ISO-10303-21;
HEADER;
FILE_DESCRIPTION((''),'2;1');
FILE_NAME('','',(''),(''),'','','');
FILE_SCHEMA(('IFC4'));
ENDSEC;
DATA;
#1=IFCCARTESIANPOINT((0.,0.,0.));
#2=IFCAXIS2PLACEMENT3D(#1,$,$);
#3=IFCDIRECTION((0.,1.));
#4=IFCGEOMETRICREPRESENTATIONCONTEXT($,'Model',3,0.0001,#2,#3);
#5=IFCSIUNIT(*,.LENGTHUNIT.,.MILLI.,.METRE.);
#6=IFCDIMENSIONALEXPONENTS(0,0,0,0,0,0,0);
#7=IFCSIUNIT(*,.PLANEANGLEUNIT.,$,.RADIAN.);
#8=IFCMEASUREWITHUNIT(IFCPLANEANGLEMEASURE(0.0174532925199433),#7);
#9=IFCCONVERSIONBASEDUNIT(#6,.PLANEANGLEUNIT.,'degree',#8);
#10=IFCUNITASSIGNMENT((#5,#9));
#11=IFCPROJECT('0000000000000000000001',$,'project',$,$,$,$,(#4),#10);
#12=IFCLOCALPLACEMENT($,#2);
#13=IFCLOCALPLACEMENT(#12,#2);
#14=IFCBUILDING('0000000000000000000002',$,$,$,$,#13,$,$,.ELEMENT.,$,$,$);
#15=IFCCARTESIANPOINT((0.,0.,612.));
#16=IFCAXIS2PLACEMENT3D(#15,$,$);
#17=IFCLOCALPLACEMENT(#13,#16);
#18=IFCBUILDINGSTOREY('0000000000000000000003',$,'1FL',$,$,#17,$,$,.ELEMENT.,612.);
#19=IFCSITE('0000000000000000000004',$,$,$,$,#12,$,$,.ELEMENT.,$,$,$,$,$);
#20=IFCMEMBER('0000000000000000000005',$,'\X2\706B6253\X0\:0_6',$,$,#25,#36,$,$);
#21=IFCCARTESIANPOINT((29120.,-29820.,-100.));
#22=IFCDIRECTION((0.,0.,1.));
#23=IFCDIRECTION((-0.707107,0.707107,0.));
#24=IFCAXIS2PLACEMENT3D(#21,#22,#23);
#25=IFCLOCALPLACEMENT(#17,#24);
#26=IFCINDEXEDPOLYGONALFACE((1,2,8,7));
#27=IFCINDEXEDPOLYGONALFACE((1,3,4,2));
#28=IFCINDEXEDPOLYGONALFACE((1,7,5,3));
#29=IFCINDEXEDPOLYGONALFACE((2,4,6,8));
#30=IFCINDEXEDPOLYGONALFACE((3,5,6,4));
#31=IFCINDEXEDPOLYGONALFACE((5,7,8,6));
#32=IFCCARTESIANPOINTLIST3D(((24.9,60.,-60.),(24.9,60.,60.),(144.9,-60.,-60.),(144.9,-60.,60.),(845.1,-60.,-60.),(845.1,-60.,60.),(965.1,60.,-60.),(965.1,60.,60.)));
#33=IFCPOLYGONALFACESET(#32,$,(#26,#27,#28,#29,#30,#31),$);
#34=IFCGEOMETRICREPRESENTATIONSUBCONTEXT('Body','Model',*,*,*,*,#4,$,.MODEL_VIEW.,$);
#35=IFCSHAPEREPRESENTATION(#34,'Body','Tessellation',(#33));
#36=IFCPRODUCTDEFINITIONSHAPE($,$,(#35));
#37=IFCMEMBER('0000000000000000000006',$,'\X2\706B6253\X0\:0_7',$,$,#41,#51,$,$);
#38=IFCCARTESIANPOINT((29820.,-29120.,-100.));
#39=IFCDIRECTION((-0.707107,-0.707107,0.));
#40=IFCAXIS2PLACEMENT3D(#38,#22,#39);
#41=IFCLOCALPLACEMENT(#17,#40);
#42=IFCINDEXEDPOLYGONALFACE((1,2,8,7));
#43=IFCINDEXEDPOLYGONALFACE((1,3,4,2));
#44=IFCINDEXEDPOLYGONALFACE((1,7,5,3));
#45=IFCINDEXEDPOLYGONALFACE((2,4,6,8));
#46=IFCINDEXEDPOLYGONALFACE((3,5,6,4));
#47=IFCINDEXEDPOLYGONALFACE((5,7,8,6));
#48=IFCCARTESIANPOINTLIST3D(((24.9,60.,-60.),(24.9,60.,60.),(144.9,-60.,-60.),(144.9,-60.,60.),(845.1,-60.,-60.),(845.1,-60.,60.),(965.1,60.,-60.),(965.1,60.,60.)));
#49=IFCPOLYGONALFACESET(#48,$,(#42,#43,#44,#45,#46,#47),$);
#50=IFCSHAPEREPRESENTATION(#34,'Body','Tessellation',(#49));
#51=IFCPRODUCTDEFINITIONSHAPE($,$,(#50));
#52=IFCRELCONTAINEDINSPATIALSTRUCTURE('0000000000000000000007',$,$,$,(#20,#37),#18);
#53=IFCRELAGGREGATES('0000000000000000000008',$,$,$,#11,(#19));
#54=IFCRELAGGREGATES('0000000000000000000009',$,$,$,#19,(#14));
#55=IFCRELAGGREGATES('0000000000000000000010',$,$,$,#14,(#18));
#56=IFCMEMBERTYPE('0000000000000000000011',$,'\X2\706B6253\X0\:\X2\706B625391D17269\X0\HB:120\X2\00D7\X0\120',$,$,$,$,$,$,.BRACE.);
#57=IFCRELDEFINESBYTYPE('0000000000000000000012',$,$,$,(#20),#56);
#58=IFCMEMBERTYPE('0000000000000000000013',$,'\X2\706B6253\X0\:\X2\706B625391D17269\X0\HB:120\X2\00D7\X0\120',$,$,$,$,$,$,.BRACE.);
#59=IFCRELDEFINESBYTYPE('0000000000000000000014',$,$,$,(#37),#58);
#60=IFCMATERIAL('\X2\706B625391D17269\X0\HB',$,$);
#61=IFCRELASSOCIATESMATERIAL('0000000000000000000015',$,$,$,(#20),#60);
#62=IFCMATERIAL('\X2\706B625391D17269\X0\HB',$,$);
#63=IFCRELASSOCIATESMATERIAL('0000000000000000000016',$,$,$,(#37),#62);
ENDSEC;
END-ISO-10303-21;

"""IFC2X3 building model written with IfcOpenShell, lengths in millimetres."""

from ifc_helpers import new_model, entity, si_unit, converted_unit, direction, frame, origin, place, context, subcontext, project, spatial, polyline, outline, extrude, material, type_object, element, save


model = new_model("IFC2X3")

# Units and contexts
model_context = context("Model", 3, precision=0.0001, world=origin(), true_north=direction((0.0, 1.0)))
body_context = subcontext(model_context, "Body", "Model", "MODEL_VIEW")
ifc_project = project(units=[si_unit("LENGTHUNIT", "METRE", prefix="MILLI"), converted_unit("PLANEANGLEUNIT", "degree", entity("IfcPlaneAngleMeasure", 0.0174532925199433), si_unit("PLANEANGLEUNIT", "RADIAN"), dimensions=[0, 0, 0, 0, 0, 0, 0])], contexts=[model_context])

# Site, building, storey
site_placement = place(None, origin())
site = spatial("IfcSite", under=ifc_project, at=site_placement, CompositionType="ELEMENT")
building_placement = place(site_placement, origin())
building = spatial("IfcBuilding", under=site, at=building_placement, CompositionType="ELEMENT")
storey_placement = place(building_placement, frame((0.0, 0.0, 612.0)))
storey = spatial("IfcBuildingStorey", under=building, at=storey_placement, Name="1FL", CompositionType="ELEMENT", Elevation=612.0)

# Members
ifc_material_1 = material(Name="火打金物HB")
member_type_1 = type_object("IfcMemberType", Name="火打:火打金物HB:120×120", PredefinedType="BRACE")
member_1_placement = place(storey_placement, frame((29120.0, -29820.0, -100.0), z_axis=(0.0, 0.0, 1.0), x_axis=(-0.707107, 0.707107, 0.0)))
element("IfcMember", 1, at=member_1_placement, inside=storey, type_object=member_type_1, material=ifc_material_1, Name="火打:0_6", context=body_context, shape_type="SweptSolid", body=[
    extrude(outline(polyline([(144.9, -60.0, 0.0), (24.9, 60.0, 0.0), (965.1, 60.0, 0.0), (845.1, -60.0, 0.0), (144.9, -60.0, 0.0)])), frame((0.0, 0.0, -60.0), z_axis=(0.0, 0.0, 1.0), x_axis=(1.0, 0.0, 0.0)), (0.0, 0.0, 1.0), 120.0),
])
ifc_material_2 = material(Name="火打金物HB")
member_type_2 = type_object("IfcMemberType", Name="火打:火打金物HB:120×120", PredefinedType="BRACE")
member_2_placement = place(storey_placement, frame((29820.0, -29120.0, -100.0), z_axis=(0.0, 0.0, 1.0), x_axis=(-0.707107, -0.707107, 0.0)))
element("IfcMember", 2, at=member_2_placement, inside=storey, type_object=member_type_2, material=ifc_material_2, Name="火打:0_7", context=body_context, shape_type="SweptSolid", body=[
    extrude(outline(polyline([(144.9, -60.0, 0.0), (24.9, 60.0, 0.0), (965.1, 60.0, 0.0), (845.1, -60.0, 0.0), (144.9, -60.0, 0.0)])), frame((0.0, 0.0, -60.0), z_axis=(0.0, 0.0, 1.0), x_axis=(1.0, 0.0, 0.0)), (0.0, 0.0, 1.0), 120.0),
])

save(model, "model.ifc")
